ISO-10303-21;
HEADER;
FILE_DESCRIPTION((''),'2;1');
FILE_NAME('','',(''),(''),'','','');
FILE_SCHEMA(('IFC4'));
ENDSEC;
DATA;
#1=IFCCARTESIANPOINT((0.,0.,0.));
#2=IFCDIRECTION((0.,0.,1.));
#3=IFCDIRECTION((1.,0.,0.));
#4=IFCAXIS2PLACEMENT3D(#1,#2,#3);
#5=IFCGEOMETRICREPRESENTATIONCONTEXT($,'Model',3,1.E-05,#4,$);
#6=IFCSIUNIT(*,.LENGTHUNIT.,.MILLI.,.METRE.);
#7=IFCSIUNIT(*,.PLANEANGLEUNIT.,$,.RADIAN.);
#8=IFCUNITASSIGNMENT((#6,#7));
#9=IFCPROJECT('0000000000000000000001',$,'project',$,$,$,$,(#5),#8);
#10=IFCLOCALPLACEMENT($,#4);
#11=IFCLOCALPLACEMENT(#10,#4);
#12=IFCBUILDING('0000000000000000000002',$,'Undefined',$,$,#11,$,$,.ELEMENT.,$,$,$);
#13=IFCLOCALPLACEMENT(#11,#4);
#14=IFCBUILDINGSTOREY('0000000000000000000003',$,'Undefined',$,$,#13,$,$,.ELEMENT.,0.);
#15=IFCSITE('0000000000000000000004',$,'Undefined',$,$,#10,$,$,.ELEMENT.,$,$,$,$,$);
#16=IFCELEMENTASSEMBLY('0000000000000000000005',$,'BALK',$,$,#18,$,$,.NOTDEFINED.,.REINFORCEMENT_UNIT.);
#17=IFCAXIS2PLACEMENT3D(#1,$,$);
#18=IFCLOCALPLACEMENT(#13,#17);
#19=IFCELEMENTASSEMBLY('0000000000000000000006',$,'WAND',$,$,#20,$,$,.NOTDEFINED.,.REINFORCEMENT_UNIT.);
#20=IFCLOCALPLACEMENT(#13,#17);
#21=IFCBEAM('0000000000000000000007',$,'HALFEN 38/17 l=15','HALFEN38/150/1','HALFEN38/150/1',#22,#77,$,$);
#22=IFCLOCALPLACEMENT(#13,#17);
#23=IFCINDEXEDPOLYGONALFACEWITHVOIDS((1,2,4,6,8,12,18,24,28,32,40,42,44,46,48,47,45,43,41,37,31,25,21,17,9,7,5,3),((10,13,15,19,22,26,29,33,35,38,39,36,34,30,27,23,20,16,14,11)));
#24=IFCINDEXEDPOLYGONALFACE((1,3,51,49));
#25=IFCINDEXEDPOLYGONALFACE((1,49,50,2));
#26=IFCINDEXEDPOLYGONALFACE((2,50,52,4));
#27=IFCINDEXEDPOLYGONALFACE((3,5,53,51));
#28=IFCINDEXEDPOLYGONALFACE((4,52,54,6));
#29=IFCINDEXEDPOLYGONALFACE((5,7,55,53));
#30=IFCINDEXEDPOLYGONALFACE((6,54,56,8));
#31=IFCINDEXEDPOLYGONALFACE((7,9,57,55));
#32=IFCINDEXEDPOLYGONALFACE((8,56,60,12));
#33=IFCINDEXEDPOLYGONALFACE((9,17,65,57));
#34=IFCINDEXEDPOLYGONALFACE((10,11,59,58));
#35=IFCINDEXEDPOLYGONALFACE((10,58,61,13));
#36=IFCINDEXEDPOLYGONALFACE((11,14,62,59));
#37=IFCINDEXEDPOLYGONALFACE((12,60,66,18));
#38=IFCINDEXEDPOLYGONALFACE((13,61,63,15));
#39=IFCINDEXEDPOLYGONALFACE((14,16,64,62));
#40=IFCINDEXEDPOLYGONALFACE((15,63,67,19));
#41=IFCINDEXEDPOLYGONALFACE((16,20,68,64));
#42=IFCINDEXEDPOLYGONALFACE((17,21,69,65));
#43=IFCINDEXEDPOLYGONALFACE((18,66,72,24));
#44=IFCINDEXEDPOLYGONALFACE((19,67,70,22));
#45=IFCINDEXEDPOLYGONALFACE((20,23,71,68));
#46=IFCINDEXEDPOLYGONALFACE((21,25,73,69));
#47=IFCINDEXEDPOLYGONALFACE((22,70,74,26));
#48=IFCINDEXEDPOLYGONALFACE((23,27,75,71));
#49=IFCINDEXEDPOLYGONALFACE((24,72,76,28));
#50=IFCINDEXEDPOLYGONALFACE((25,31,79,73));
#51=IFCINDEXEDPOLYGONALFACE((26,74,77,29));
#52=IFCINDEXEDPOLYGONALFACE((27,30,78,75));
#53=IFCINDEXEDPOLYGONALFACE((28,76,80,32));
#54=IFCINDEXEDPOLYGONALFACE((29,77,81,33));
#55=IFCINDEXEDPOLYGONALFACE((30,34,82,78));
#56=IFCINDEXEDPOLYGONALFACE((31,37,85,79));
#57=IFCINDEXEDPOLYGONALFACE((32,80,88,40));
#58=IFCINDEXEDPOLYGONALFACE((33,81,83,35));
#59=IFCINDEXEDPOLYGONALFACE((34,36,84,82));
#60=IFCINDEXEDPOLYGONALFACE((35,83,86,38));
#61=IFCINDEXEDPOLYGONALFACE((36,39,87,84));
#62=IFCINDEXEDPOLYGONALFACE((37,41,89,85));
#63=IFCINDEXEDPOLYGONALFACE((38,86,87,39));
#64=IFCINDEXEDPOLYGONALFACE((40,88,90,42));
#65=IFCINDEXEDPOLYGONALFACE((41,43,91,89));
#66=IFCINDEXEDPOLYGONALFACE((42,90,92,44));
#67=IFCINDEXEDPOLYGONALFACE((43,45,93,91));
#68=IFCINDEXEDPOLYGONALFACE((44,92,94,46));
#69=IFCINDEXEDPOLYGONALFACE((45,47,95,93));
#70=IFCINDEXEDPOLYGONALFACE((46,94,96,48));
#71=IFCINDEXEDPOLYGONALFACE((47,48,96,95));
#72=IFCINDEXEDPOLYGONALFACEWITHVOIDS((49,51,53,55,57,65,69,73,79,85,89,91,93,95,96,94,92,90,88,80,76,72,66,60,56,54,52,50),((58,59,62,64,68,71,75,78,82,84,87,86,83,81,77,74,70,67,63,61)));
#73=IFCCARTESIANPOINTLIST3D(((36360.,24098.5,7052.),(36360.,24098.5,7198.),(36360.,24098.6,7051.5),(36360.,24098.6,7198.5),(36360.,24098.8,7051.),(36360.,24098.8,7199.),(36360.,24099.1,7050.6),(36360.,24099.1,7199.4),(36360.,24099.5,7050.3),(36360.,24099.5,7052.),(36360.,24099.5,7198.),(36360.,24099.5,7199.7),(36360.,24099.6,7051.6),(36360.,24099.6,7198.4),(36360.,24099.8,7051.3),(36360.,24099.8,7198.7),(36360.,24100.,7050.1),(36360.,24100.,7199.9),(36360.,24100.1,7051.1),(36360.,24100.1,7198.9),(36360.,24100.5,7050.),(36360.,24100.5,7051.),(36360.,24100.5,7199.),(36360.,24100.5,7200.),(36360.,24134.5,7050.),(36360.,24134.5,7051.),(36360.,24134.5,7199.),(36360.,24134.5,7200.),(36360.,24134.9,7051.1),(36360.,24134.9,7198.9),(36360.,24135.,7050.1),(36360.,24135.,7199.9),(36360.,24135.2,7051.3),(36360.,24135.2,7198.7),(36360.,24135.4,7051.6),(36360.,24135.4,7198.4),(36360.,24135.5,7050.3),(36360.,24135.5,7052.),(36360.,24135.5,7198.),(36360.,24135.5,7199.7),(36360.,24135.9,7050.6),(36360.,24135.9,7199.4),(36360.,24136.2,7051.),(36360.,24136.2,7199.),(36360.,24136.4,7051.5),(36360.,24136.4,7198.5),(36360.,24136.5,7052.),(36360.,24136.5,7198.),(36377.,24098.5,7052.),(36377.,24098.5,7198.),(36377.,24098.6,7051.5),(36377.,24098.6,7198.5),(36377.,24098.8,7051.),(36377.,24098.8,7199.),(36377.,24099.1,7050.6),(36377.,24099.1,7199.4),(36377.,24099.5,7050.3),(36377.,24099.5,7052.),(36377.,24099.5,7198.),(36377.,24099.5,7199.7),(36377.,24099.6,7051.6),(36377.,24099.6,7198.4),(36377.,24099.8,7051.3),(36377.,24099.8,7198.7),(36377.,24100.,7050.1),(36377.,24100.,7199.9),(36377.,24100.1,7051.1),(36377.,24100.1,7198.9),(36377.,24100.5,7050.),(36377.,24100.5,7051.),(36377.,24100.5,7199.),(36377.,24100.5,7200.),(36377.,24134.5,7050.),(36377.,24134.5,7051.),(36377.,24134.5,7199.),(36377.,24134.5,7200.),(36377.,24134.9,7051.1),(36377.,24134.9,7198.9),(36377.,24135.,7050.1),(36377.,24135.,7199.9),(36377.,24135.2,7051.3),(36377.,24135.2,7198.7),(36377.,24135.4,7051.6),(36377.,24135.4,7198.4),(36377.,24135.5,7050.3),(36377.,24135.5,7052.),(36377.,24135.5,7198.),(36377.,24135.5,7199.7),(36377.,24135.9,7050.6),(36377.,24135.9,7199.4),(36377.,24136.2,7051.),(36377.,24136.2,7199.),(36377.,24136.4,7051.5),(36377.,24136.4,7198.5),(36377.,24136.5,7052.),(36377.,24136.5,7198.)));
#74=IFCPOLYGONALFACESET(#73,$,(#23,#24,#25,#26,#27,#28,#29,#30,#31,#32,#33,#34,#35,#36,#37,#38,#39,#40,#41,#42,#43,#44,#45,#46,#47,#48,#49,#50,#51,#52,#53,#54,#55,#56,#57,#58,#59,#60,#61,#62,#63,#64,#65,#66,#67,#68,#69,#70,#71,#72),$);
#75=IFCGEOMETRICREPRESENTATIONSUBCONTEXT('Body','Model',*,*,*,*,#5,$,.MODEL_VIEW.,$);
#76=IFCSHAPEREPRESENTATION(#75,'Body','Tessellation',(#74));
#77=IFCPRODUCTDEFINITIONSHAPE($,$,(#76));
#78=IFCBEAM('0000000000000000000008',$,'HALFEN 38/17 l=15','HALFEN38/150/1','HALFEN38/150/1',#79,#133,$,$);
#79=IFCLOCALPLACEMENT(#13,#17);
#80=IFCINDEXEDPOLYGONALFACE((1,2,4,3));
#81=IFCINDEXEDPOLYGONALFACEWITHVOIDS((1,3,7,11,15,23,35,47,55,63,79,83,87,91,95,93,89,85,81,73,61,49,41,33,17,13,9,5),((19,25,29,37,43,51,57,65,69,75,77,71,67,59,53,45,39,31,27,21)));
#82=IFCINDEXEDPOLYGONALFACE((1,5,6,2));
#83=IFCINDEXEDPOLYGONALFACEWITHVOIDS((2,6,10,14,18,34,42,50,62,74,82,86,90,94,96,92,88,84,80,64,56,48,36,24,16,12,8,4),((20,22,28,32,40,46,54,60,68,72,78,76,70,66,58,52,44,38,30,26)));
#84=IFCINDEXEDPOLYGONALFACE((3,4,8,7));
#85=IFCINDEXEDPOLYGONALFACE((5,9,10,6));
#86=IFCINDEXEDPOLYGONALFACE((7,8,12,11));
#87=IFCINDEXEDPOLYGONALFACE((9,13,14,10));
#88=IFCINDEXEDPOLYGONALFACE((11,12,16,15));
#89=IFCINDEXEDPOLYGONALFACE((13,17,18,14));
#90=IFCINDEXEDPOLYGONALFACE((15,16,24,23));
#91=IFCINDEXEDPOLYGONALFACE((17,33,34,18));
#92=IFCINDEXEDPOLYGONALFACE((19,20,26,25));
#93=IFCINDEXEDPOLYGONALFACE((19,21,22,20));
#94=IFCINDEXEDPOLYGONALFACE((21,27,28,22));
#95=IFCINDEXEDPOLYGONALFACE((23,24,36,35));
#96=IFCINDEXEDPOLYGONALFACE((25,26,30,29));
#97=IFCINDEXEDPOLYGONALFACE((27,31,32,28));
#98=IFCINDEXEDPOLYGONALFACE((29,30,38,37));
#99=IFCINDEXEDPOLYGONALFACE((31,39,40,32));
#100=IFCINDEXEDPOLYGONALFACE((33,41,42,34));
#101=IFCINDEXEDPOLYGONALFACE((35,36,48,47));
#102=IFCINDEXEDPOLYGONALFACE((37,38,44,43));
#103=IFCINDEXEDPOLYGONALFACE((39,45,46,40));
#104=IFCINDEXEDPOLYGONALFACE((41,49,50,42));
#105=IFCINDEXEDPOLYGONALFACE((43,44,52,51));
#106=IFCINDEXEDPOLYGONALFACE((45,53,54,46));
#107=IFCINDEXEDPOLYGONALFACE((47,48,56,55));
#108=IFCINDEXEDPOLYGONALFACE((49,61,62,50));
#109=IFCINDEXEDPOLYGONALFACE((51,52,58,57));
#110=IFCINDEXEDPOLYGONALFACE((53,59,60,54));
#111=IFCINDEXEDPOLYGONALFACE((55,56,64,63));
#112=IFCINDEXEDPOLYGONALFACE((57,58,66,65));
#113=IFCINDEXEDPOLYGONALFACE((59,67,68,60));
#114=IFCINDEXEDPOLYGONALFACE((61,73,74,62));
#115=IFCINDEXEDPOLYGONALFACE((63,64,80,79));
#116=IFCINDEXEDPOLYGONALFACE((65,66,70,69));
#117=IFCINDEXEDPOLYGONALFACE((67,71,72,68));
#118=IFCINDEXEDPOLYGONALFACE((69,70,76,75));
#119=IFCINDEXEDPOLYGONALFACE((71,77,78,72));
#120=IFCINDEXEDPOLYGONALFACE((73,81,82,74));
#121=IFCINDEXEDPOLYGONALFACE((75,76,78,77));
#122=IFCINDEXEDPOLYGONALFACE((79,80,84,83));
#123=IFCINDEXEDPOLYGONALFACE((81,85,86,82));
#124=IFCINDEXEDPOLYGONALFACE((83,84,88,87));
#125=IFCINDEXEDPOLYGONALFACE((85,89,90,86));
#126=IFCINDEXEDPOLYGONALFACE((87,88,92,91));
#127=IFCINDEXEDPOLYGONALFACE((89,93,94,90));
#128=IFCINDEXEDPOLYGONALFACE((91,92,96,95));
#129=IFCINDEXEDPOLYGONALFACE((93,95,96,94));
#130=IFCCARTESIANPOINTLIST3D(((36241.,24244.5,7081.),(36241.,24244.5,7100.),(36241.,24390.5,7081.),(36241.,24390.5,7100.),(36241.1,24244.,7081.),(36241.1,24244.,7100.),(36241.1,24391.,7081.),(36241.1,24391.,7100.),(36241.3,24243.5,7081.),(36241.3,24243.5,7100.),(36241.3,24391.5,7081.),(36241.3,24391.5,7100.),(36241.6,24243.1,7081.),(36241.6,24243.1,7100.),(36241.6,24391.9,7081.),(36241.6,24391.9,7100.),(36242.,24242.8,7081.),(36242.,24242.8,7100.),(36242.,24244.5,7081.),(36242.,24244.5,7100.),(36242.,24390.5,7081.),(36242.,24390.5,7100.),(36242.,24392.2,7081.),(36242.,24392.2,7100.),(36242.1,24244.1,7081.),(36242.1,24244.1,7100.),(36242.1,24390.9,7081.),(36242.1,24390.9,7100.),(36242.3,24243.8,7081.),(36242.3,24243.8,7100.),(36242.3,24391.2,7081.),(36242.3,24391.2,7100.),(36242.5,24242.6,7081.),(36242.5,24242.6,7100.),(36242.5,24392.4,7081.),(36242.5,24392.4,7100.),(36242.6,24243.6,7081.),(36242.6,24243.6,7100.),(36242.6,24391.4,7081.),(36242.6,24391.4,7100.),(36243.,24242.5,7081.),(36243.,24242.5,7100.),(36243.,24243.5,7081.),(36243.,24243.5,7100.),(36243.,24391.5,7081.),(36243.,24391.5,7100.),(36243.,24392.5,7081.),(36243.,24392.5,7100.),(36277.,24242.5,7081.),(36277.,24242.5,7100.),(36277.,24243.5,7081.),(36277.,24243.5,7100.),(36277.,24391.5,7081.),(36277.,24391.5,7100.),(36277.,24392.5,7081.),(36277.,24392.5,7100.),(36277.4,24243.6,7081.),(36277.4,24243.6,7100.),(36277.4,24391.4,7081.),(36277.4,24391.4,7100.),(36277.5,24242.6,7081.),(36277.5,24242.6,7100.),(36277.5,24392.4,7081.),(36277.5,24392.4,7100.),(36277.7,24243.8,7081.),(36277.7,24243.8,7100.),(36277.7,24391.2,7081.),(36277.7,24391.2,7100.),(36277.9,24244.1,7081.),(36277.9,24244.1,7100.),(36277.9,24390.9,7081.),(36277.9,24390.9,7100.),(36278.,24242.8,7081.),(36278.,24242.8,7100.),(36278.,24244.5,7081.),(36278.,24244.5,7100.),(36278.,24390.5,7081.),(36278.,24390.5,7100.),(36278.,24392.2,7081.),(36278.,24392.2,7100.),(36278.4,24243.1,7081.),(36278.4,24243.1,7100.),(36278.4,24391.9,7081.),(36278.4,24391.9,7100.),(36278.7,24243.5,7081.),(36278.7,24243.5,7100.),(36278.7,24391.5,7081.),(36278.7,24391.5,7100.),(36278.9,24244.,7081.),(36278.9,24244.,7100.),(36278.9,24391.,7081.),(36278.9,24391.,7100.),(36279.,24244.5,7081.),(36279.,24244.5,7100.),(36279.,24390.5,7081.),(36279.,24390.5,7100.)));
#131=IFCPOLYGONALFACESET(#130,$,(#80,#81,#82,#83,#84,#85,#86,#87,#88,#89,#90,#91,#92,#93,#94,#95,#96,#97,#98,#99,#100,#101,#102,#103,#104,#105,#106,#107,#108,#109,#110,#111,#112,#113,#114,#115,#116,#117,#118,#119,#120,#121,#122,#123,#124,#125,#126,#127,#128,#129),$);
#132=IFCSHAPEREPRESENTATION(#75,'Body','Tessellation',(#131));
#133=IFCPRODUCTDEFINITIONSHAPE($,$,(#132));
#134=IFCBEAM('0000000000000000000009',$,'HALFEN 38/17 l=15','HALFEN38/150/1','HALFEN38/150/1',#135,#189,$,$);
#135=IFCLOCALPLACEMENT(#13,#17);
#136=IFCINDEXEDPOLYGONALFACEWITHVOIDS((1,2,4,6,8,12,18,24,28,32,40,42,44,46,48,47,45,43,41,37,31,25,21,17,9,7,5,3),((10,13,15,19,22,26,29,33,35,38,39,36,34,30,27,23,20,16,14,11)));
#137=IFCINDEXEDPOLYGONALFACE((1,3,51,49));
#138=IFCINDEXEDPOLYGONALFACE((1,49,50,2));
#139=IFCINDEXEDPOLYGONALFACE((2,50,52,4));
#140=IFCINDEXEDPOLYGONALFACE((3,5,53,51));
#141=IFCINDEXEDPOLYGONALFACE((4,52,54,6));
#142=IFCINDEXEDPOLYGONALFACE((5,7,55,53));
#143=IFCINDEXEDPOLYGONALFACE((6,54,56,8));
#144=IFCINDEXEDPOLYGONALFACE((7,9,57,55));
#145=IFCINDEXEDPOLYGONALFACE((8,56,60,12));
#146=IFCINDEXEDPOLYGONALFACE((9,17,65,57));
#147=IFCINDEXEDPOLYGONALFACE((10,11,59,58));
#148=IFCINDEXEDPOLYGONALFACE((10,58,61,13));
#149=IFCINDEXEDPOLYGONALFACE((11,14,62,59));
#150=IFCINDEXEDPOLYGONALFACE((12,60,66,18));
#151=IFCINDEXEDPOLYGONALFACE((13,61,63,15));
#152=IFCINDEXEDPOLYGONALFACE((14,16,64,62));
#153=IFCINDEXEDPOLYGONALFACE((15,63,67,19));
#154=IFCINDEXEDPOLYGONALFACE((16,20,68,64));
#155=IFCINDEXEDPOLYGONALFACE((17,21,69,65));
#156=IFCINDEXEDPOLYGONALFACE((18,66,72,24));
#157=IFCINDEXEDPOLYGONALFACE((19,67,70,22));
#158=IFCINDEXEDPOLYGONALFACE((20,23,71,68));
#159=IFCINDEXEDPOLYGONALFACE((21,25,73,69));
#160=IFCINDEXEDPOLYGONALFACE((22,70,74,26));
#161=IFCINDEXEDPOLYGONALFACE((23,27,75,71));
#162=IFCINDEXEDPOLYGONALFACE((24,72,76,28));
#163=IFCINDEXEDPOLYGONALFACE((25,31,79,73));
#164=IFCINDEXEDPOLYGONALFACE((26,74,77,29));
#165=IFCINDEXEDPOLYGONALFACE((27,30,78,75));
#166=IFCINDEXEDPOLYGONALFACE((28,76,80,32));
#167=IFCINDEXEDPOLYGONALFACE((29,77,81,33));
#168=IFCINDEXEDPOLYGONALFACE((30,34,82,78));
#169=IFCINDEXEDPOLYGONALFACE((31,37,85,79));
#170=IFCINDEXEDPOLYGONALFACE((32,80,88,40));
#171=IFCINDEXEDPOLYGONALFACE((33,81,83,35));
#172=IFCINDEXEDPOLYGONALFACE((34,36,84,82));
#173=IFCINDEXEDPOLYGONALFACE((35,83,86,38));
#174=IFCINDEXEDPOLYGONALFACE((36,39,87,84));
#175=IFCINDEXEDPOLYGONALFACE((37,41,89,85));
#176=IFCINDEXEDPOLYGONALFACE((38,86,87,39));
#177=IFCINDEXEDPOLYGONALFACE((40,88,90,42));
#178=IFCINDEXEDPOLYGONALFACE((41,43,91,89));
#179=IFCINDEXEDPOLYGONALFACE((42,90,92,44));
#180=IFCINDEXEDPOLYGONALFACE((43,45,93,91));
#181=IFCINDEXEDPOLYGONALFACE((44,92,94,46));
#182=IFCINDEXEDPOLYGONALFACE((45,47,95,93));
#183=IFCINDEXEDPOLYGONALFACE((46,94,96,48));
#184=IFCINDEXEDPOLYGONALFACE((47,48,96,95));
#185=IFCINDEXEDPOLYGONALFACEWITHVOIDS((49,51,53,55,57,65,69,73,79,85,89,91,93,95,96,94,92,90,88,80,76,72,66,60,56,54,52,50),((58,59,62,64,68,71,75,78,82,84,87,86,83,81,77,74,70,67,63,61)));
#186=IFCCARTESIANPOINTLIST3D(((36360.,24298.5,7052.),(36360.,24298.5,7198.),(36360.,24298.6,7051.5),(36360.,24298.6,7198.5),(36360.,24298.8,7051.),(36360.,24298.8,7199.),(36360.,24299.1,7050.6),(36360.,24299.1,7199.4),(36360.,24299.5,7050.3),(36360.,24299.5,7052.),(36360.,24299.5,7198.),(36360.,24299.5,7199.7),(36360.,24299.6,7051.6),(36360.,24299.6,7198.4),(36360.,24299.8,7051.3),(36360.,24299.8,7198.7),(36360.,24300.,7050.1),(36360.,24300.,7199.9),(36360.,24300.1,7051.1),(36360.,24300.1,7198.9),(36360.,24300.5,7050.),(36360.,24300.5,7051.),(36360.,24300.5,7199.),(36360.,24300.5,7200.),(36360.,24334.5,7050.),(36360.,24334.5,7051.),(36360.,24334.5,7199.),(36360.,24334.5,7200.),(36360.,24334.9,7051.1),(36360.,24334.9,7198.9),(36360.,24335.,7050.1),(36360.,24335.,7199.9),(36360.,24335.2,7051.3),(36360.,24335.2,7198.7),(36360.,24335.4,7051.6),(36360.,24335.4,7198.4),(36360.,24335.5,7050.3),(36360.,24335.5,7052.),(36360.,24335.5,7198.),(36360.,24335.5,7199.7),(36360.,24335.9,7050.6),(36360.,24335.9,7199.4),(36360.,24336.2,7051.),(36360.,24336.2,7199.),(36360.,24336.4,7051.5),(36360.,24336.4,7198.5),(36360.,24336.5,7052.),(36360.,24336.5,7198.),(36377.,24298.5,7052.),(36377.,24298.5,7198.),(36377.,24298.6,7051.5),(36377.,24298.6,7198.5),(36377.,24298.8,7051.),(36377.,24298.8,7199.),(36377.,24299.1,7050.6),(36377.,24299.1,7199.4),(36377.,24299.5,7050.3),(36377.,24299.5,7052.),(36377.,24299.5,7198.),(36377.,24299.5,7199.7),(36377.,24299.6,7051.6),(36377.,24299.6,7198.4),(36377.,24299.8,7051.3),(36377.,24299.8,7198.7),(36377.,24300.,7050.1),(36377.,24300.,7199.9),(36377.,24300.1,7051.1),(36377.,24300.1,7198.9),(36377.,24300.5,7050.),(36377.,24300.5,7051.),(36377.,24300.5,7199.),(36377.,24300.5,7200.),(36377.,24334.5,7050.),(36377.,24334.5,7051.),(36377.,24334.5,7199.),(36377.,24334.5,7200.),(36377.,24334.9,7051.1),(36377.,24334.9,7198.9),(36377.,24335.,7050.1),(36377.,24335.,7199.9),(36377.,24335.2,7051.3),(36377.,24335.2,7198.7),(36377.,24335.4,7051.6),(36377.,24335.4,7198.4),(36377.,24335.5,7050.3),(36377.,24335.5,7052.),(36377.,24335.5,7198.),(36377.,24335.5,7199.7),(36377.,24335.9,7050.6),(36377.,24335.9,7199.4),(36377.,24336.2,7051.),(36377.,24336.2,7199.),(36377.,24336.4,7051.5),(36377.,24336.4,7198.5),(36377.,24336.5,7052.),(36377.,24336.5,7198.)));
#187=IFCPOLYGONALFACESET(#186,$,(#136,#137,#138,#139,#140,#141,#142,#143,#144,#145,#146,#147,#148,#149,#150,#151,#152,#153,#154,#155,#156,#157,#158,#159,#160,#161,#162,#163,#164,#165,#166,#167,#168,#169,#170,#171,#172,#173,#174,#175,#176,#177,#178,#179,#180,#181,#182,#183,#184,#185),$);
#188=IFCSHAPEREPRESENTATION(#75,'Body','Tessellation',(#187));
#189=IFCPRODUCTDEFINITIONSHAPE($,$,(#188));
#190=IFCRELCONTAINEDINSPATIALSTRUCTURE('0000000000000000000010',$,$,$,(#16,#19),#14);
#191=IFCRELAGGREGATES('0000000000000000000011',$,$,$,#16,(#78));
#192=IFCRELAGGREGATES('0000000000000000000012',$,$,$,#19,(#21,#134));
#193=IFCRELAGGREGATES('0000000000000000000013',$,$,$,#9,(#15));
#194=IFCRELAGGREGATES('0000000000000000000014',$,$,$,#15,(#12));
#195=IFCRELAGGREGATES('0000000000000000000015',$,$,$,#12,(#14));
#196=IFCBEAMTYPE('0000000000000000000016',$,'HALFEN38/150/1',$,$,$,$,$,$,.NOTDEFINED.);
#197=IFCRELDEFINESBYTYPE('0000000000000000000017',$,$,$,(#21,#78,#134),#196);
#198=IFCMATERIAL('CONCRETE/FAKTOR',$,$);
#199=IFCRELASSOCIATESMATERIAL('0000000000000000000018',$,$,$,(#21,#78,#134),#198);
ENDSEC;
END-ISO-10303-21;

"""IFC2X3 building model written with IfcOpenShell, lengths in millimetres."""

from ifc_helpers import new_model, si_unit, frame, frame_2d, origin_with_axes, place, context, subcontext, project, spatial, hollow_rectangle, extrude, material, type_object, element, aggregate, save


model = new_model("IFC2X3")

# Units and contexts
model_context = context("Model", 3, precision=1e-05, world=origin_with_axes())
body_context = subcontext(model_context, "Body", "Model", "MODEL_VIEW")
ifc_project = project(units=[si_unit("LENGTHUNIT", "METRE", prefix="MILLI"), si_unit("PLANEANGLEUNIT", "RADIAN")], contexts=[model_context])

# Site, building, storey
site_placement = place(None, origin_with_axes())
site = spatial("IfcSite", under=ifc_project, at=site_placement, Name="Undefined", CompositionType="ELEMENT")
building_placement = place(site_placement, origin_with_axes())
building = spatial("IfcBuilding", under=site, at=building_placement, Name="Undefined", CompositionType="ELEMENT")
storey_placement = place(building_placement, origin_with_axes())
storey = spatial("IfcBuildingStorey", under=building, at=storey_placement, Name="Undefined", CompositionType="ELEMENT", Elevation=0.0)

# Element assembly
assembly_1_placement = place(storey_placement, origin_with_axes())
assembly_1 = element("IfcElementAssembly", 1, at=assembly_1_placement, inside=storey, Name="BALK", AssemblyPlace="NOTDEFINED", PredefinedType="REINFORCEMENT_UNIT")
ifc_material_1 = material(Name="CONCRETE/FAKTOR")

# Element assembly
assembly_2_placement = place(storey_placement, origin_with_axes())
assembly_2 = element("IfcElementAssembly", 2, at=assembly_2_placement, inside=storey, Name="WAND", AssemblyPlace="NOTDEFINED", PredefinedType="REINFORCEMENT_UNIT")

# Beams
beam_type_1 = type_object("IfcBeamType", Name="HALFEN38/150/1", PredefinedType="NOTDEFINED")
beam_1_placement = place(assembly_2_placement, frame((36360.0, 24117.5, 7125.0), z_axis=(0.0, -1.0, 0.0), x_axis=(1.0, 0.0, 0.0)))
beam_1 = element("IfcBeam", 3, at=beam_1_placement, type_object=beam_type_1, material=ifc_material_1, Name="HALFEN 38/17 l=15", Description="HALFEN38/150/1", ObjectType="HALFEN38/150/1", context=body_context, shape_type="SweptSolid", body=[
    extrude(hollow_rectangle(XDim=150.0, YDim=38.0, WallThickness=1.0, InnerFilletRadius=1.0, OuterFilletRadius=2.0, at=frame_2d((0.0, 0.0), x_axis=(1.0, 0.0))), frame((17.0, 0.0, 0.0), z_axis=(-1.0, 0.0, 0.0), x_axis=(0.0, -1.0, 0.0)), (0.0, 0.0, 1.0), 17.0),
])
beam_2_placement = place(assembly_1_placement, frame((36260.0, 24317.5, 7100.0), z_axis=(1.0, 0.0, 0.0), x_axis=(0.0, 0.0, -1.0)))
beam_2 = element("IfcBeam", 4, at=beam_2_placement, type_object=beam_type_1, material=ifc_material_1, Name="HALFEN 38/17 l=15", Description="HALFEN38/150/1", ObjectType="HALFEN38/150/1", context=body_context, shape_type="SweptSolid", body=[
    extrude(hollow_rectangle(XDim=150.0, YDim=38.0, WallThickness=1.0, InnerFilletRadius=1.0, OuterFilletRadius=2.0, at=frame_2d((0.0, 0.0), x_axis=(1.0, 0.0))), frame((19.0, 0.0, 0.0), z_axis=(-1.0, 0.0, 0.0), x_axis=(0.0, -1.0, 0.0)), (0.0, 0.0, 1.0), 19.0),
])
beam_3_placement = place(assembly_2_placement, frame((36360.0, 24317.5, 7125.0), z_axis=(0.0, -1.0, 0.0), x_axis=(1.0, 0.0, 0.0)))
beam_3 = element("IfcBeam", 5, at=beam_3_placement, type_object=beam_type_1, material=ifc_material_1, Name="HALFEN 38/17 l=15", Description="HALFEN38/150/1", ObjectType="HALFEN38/150/1", context=body_context, shape_type="SweptSolid", body=[
    extrude(hollow_rectangle(XDim=150.0, YDim=38.0, WallThickness=1.0, InnerFilletRadius=1.0, OuterFilletRadius=2.0, at=frame_2d((0.0, 0.0), x_axis=(1.0, 0.0))), frame((17.0, 0.0, 0.0), z_axis=(-1.0, 0.0, 0.0), x_axis=(0.0, -1.0, 0.0)), (0.0, 0.0, 1.0), 17.0),
])

aggregate(assembly_1, [beam_2])
aggregate(assembly_2, [beam_1, beam_3])

save(model, "model.ifc")
